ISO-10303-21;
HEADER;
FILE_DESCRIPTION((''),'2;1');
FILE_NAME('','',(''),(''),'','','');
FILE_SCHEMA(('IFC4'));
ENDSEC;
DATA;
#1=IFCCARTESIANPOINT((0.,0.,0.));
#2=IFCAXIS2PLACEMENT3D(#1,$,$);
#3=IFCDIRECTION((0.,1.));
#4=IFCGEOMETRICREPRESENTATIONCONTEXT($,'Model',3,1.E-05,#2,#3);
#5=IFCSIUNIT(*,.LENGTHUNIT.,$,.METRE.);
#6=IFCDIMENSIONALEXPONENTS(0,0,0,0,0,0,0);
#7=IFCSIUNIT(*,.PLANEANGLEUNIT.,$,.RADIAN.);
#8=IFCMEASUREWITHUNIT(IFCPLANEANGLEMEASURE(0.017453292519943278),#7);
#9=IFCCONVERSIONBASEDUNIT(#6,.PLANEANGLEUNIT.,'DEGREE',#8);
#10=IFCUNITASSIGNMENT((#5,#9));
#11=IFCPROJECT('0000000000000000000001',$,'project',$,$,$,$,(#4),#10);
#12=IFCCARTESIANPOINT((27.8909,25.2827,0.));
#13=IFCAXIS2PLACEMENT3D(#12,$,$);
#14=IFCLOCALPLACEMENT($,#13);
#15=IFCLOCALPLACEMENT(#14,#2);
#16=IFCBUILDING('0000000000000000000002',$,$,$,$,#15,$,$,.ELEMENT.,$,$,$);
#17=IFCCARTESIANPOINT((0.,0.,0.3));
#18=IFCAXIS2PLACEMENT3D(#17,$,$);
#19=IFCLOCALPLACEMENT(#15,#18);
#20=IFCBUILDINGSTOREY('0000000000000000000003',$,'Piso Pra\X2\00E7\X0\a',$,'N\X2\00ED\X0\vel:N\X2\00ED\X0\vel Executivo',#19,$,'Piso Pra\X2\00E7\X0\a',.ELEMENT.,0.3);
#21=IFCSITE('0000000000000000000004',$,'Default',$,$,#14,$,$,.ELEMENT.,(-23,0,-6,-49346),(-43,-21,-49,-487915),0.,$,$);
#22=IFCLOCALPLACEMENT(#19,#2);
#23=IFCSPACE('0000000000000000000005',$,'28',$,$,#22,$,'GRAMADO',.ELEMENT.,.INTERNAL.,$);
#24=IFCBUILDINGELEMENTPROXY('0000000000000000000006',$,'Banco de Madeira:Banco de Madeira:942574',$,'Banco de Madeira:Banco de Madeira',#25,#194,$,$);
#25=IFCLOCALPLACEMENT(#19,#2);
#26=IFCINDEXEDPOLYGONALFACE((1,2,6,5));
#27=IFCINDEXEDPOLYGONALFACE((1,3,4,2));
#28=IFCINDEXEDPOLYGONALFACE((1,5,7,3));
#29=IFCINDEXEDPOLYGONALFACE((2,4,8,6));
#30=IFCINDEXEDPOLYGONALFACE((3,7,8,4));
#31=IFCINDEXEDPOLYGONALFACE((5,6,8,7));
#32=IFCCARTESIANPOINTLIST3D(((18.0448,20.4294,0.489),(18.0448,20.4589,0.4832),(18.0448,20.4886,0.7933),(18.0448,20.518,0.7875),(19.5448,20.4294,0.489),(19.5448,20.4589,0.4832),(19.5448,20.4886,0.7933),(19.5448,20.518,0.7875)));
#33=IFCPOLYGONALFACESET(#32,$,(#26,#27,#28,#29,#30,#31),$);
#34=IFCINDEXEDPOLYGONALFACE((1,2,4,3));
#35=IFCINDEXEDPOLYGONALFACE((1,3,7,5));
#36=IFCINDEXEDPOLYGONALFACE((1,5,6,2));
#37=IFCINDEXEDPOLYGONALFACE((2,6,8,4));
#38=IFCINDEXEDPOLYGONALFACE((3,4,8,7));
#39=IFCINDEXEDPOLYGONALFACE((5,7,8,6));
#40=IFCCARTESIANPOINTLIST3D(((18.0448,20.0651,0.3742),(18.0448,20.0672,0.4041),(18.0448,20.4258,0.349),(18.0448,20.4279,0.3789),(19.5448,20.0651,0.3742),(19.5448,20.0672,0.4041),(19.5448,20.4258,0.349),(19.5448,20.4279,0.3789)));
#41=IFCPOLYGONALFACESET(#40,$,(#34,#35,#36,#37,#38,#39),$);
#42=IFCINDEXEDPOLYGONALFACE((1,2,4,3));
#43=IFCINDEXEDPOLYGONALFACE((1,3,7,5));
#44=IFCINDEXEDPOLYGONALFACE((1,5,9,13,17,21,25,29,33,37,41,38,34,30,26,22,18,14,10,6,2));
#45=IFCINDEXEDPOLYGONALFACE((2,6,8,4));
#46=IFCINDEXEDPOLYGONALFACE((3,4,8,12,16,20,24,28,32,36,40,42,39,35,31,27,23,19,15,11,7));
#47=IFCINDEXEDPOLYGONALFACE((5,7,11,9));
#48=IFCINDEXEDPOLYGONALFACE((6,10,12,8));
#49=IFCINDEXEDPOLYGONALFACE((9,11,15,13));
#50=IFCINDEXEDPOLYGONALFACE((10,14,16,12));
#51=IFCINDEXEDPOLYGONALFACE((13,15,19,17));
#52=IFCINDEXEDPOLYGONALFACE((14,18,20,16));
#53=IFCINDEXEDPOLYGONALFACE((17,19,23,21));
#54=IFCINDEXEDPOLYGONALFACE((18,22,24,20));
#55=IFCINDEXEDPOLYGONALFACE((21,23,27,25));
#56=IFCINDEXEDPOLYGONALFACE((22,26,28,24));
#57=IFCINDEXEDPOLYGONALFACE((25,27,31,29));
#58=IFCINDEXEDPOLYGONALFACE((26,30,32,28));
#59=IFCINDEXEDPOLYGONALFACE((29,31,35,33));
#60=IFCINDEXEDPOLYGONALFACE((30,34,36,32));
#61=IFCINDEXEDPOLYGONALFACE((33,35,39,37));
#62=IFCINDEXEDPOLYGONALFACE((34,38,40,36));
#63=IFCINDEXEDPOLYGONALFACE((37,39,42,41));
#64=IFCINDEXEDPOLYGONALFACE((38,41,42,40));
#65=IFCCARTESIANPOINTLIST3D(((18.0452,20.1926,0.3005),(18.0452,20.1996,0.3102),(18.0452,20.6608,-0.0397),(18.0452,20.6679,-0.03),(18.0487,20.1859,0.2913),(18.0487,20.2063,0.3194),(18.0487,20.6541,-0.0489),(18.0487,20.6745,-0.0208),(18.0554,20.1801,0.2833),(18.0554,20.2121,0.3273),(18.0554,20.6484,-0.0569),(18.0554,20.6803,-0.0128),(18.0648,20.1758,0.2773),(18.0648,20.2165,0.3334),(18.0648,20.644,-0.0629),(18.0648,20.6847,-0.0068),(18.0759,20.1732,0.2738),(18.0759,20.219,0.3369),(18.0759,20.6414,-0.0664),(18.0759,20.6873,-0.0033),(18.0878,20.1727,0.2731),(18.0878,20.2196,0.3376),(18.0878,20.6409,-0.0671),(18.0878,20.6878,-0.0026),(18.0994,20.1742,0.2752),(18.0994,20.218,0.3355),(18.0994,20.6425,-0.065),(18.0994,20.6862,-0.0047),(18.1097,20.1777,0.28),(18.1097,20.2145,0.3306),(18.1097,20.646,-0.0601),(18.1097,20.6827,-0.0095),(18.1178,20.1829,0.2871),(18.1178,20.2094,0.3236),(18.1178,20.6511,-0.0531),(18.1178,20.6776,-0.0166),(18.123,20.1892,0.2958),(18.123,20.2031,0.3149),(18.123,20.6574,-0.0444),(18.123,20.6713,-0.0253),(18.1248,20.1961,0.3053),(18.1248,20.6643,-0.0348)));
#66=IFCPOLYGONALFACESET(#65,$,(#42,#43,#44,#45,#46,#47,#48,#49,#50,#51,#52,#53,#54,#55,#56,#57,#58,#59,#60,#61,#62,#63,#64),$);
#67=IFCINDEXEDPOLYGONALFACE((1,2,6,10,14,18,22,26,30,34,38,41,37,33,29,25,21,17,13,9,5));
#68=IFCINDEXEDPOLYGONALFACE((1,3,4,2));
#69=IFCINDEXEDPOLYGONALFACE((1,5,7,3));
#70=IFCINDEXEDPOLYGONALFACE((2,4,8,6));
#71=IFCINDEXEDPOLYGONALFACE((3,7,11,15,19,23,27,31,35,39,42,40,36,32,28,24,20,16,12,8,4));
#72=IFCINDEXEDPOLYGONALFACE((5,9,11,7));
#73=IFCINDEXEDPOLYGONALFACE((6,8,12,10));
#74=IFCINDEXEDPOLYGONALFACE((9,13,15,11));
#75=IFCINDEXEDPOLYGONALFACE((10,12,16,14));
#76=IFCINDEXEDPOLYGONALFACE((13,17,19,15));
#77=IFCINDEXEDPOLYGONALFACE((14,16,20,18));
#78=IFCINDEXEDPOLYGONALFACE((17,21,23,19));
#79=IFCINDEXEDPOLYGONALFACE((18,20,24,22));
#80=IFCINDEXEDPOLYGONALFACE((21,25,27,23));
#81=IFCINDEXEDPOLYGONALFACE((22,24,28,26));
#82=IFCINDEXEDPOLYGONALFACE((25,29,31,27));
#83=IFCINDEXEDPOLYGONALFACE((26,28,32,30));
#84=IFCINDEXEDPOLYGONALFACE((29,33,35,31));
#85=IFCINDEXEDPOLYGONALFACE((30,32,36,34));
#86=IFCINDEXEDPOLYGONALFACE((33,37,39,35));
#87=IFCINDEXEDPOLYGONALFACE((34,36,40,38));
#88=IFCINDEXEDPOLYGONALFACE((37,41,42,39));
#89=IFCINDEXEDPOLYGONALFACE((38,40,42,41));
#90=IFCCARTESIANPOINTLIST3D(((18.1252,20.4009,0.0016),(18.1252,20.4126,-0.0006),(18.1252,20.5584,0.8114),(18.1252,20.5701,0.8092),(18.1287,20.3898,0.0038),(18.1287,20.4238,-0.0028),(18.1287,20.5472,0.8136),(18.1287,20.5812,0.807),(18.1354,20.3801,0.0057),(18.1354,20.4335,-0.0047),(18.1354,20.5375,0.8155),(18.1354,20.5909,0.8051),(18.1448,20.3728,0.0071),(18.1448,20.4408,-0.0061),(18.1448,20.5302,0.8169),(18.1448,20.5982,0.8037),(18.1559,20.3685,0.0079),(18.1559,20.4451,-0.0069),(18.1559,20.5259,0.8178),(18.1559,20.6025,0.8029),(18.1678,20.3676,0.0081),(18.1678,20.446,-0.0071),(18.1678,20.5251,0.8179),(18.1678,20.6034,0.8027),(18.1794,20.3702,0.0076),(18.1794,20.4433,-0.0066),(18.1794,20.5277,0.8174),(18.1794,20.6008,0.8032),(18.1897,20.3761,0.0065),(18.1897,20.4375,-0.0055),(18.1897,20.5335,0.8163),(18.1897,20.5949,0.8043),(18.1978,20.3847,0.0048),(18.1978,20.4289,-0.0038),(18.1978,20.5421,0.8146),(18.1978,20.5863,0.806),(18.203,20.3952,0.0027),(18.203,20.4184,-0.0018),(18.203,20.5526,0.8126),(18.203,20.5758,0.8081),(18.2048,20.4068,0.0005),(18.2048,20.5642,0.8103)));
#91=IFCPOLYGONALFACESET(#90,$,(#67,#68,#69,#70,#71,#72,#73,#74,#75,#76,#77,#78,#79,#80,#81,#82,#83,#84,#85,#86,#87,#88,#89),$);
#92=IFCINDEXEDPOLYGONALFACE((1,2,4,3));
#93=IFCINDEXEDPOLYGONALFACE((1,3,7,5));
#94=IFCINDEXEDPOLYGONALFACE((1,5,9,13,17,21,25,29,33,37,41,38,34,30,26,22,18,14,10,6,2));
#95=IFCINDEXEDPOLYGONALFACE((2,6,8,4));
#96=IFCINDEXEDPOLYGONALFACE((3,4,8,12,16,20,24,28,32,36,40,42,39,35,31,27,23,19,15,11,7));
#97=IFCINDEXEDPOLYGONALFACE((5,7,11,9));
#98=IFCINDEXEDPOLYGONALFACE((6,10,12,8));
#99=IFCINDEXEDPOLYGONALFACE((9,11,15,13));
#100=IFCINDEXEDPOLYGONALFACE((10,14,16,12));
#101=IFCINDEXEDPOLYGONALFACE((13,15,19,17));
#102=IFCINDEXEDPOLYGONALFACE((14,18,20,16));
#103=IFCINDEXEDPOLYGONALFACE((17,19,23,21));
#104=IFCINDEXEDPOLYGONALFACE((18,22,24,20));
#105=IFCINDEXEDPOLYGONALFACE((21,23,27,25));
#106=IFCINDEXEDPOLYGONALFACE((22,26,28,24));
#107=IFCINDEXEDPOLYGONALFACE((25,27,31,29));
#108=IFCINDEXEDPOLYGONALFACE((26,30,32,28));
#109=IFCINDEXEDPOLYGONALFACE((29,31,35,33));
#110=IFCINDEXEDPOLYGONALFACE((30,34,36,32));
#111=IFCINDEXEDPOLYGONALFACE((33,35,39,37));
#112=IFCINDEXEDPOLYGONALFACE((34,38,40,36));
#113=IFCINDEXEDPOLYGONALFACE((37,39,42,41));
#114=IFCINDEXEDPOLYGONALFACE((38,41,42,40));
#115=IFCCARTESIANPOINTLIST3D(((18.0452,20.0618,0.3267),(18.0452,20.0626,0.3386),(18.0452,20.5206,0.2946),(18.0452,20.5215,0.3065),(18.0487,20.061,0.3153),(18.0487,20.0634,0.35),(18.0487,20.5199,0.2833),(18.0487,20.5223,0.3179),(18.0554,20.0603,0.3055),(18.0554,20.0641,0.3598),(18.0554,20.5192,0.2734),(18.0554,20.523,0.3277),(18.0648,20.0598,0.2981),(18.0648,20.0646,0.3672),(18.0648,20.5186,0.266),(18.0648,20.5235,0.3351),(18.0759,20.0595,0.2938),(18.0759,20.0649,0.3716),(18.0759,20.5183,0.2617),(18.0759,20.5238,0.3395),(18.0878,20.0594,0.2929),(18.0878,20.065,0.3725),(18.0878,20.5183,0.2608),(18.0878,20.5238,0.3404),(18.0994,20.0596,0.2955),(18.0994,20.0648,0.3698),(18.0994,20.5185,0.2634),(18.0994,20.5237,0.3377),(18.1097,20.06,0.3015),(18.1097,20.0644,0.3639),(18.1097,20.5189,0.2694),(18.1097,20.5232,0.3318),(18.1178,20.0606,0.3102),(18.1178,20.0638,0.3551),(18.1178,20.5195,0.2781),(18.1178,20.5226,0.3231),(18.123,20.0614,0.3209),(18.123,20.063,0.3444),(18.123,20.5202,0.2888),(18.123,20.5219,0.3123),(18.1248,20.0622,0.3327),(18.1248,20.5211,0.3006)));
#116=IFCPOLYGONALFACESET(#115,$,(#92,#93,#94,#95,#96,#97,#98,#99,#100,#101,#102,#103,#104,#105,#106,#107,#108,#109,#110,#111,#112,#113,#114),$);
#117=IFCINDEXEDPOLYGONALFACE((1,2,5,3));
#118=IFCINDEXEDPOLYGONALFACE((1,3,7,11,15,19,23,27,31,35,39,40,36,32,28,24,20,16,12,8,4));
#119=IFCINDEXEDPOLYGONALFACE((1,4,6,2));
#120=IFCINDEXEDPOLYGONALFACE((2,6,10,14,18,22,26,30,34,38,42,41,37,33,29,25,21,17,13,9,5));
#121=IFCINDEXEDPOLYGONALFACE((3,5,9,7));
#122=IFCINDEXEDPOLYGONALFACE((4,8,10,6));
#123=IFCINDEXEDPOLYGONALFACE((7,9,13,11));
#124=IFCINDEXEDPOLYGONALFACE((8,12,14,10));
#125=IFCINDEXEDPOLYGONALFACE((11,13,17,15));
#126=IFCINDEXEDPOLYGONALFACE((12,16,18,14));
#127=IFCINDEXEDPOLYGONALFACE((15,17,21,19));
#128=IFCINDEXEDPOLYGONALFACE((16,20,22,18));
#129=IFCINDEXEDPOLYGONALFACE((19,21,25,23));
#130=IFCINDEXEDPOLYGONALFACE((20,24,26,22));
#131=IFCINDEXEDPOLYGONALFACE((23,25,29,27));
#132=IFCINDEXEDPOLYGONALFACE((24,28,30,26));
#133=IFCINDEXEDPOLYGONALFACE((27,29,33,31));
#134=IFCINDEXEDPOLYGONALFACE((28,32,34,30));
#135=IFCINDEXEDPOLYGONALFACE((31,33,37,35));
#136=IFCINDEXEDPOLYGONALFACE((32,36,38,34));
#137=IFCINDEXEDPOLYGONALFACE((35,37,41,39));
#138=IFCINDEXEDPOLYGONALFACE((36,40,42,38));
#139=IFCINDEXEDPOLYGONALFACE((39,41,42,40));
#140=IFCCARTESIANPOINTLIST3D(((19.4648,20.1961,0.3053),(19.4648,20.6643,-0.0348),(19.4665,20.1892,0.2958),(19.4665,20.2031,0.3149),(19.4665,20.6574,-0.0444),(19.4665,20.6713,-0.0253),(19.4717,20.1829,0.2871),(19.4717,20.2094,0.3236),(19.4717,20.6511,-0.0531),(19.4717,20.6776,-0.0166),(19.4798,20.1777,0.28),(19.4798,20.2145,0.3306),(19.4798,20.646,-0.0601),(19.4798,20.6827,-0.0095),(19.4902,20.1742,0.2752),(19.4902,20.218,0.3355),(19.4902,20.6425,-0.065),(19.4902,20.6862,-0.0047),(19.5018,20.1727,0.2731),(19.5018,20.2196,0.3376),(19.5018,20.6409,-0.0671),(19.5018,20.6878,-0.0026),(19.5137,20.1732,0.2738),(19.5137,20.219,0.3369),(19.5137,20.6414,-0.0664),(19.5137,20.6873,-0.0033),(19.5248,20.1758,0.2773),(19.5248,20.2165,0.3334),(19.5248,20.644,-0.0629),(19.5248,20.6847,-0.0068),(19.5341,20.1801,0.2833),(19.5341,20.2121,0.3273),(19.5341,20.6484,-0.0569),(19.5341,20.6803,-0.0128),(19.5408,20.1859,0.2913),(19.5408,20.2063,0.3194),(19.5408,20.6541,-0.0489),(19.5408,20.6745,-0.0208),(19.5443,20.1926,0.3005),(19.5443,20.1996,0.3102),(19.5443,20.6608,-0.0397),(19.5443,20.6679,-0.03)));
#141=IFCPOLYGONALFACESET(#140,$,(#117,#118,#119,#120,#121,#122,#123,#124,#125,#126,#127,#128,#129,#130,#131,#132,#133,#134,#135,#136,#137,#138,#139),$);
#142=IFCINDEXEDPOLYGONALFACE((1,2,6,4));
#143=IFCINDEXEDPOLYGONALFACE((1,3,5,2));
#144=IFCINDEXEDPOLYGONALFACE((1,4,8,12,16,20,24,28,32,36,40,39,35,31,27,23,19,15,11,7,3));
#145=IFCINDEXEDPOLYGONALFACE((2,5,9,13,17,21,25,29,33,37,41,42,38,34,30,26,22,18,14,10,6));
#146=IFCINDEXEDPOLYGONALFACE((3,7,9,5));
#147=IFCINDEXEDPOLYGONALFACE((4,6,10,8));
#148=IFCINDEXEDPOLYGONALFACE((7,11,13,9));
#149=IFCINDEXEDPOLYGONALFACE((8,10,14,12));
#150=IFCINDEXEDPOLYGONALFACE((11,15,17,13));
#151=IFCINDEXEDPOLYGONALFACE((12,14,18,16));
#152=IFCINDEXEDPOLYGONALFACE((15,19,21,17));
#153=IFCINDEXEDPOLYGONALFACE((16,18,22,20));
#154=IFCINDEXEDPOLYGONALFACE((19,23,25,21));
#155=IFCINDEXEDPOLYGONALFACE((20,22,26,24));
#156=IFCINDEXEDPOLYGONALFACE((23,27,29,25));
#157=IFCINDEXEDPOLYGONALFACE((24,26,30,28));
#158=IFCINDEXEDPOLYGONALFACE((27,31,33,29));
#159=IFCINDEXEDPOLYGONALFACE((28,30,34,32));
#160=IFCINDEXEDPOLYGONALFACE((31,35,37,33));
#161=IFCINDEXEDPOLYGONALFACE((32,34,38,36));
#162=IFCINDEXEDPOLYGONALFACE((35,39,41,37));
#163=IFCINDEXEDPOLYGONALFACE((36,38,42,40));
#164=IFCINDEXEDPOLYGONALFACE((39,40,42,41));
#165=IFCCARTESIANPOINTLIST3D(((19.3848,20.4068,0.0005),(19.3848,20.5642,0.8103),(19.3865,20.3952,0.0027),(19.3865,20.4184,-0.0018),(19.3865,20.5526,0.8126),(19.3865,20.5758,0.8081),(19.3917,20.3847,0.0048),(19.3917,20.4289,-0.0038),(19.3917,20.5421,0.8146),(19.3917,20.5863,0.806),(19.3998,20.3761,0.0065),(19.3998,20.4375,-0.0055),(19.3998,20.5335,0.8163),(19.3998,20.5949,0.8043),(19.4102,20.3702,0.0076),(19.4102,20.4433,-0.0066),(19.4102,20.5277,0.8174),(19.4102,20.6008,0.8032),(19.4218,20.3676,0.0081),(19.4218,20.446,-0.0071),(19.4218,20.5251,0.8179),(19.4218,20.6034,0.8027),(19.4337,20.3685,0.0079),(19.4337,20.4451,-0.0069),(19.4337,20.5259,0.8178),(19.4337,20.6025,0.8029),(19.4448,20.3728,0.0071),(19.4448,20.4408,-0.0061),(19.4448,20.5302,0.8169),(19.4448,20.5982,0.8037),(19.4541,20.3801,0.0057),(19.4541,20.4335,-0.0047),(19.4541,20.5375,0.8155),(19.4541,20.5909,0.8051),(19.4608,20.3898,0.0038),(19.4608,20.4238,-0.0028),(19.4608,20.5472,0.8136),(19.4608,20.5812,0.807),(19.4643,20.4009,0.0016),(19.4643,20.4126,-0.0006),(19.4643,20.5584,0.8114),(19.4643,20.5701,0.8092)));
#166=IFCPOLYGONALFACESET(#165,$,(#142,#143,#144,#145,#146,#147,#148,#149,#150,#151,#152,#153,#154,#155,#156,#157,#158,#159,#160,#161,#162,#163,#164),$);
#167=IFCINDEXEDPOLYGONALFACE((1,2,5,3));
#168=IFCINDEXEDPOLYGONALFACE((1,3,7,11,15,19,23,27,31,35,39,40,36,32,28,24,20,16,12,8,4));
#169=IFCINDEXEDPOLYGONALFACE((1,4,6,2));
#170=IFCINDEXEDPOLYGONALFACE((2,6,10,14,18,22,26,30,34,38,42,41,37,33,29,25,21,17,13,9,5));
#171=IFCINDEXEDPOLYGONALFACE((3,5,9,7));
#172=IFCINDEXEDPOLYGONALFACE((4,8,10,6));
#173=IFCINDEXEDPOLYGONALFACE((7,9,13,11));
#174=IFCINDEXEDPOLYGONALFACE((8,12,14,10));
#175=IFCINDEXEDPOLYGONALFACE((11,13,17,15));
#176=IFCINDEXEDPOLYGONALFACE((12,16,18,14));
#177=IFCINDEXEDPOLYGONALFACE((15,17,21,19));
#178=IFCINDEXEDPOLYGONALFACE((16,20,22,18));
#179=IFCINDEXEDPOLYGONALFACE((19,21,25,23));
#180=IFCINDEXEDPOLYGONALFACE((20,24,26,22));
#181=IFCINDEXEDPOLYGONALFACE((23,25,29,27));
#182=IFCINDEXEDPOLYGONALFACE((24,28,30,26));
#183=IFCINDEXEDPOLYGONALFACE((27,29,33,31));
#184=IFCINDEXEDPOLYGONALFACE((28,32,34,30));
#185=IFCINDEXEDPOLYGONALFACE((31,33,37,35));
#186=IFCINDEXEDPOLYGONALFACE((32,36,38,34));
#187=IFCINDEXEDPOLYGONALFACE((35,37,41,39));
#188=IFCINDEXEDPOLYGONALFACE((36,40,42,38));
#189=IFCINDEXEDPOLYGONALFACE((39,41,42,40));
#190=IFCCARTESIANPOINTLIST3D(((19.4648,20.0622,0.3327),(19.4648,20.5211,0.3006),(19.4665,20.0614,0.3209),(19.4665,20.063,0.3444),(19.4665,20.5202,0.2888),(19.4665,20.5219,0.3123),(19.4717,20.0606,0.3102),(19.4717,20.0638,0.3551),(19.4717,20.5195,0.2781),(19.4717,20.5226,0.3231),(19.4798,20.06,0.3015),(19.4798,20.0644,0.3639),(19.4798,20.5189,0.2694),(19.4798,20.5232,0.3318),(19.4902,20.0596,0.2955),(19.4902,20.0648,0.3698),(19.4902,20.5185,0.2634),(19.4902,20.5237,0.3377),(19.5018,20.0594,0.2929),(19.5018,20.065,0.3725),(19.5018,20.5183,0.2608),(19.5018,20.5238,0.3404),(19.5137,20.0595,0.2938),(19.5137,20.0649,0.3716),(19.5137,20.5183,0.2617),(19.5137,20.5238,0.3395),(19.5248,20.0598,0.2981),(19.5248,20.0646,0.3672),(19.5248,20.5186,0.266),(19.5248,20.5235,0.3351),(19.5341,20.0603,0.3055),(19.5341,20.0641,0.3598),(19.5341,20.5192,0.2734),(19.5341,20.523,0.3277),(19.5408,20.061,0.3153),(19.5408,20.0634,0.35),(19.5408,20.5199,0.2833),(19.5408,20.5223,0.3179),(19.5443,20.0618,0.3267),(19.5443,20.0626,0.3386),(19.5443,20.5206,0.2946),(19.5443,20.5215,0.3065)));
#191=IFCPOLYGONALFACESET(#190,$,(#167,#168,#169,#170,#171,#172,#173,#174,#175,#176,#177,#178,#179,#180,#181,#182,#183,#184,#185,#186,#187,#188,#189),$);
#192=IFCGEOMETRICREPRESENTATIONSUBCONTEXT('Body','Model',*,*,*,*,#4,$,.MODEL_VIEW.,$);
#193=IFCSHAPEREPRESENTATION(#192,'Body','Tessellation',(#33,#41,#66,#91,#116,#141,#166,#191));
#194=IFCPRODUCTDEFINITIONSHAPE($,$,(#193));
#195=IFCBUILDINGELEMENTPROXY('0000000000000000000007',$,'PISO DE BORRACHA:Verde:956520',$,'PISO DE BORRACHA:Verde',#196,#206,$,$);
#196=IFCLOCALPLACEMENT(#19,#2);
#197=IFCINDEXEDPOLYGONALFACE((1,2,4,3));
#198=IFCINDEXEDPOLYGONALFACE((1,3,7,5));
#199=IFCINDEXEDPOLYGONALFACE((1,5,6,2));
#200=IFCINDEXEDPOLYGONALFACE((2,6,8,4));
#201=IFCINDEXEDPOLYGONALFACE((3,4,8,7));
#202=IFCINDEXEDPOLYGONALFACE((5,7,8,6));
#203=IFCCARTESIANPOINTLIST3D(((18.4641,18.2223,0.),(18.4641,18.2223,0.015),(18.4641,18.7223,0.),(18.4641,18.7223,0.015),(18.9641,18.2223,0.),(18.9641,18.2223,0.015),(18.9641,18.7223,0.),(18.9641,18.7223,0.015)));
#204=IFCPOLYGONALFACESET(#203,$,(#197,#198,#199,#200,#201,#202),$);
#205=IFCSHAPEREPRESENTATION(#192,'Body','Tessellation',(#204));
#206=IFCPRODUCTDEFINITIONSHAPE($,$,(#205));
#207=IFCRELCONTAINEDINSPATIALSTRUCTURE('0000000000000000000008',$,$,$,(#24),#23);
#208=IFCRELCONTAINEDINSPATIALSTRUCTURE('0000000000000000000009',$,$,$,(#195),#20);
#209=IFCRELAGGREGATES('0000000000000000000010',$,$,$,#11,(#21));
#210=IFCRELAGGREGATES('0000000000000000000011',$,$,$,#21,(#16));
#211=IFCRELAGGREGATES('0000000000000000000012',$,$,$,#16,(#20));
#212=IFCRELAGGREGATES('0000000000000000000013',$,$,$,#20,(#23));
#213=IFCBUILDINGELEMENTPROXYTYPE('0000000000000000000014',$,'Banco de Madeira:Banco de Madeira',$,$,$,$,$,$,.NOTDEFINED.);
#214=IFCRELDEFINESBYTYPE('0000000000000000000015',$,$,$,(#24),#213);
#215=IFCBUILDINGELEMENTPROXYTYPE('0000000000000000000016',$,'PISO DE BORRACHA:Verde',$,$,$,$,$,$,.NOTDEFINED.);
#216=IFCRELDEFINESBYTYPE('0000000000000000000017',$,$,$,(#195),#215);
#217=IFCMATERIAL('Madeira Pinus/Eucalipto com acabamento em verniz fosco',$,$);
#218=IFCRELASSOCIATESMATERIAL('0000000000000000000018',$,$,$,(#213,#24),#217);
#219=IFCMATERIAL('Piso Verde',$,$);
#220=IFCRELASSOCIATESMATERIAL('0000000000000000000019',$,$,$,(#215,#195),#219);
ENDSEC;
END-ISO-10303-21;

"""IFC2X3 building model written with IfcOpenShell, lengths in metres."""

from ifc_helpers import new_model, entity, si_unit, converted_unit, direction, frame, frame_2d, origin, origin_2d_with_axis, place, context, subcontext, project, spatial, rectangle, circle, extrude, source, transform, mapped, material, type_object, type_shapes, element, save


model = new_model("IFC2X3")

# Units and contexts
model_context = context("Model", 3, precision=1e-05, world=origin(), true_north=direction((0.0, 1.0)))
body_context = subcontext(model_context, "Body", "Model", "MODEL_VIEW")
ifc_project = project(units=[si_unit("LENGTHUNIT", "METRE"), converted_unit("PLANEANGLEUNIT", "DEGREE", entity("IfcPlaneAngleMeasure", 0.017453292519943278), si_unit("PLANEANGLEUNIT", "RADIAN"), dimensions=[0, 0, 0, 0, 0, 0, 0])], contexts=[model_context])

# Site, building, storey, space
site_placement = place(None, frame((27.8909, 25.2827, 0.0)))
site = spatial("IfcSite", under=ifc_project, at=site_placement, Name="Default", CompositionType="ELEMENT", RefLatitude=(-23, 0, -6, -49346), RefLongitude=(-43, -21, -49, -487915), RefElevation=0.0)
building_placement = place(site_placement, origin())
building = spatial("IfcBuilding", under=site, at=building_placement, CompositionType="ELEMENT")
storey_placement = place(building_placement, frame((0.0, 0.0, 0.3)))
storey = spatial("IfcBuildingStorey", under=building, at=storey_placement, Name="Piso Praça", ObjectType="Nível:Nível Executivo", LongName="Piso Praça", CompositionType="ELEMENT", Elevation=0.3)
space_placement = place(storey_placement, origin())
space = spatial("IfcSpace", under=storey, at=space_placement, Name="28", LongName="GRAMADO", CompositionType="ELEMENT", InteriorOrExteriorSpace="INTERNAL")

# Building element proxies
ifc_material_1 = material(Name="Madeira Pinus/Eucalipto com acabamento em verniz fosco")
building_element_proxy_type_1 = type_object("IfcBuildingElementProxyType", Name="Banco de Madeira:Banco de Madeira", PredefinedType="NOTDEFINED", material=ifc_material_1)
shared_shape_1 = source(origin(), body_context, "Body", "SweptSolid", [
    extrude(rectangle(XDim=0.31, YDim=0.03, at=frame_2d((0.0, 0.0), x_axis=(0.0, 1.0))), frame((-0.75, -0.1439, 0.6383), z_axis=(1.0, 0.0, 0.0), x_axis=(0.0, 0.981627, 0.190809)), (0.0, 0.0, 1.0), 1.5),
    extrude(rectangle(XDim=0.03, YDim=0.3616, at=frame_2d((0.0, 0.0), x_axis=(1.0, 0.0))), frame((-0.75, 0.0833, 0.3765), z_axis=(1.0, 0.0, 0.0), x_axis=(0.0, -0.069756, 0.997564)), (0.0, 0.0, 1.0), 1.5),
    extrude(circle(Radius=0.04, at=frame_2d((0.0, 0.0), x_axis=(1.0, 0.0))), frame((0.71, -0.3345, -0.0348), z_axis=(0.0, 0.809017, 0.587785), x_axis=(-1.0, 0.0, 0.0)), (0.0, 0.0, 1.0), 0.5788),
    extrude(circle(Radius=0.04, at=frame_2d((0.0, 0.0), x_axis=(1.0, 0.0))), frame((0.63, -0.2344, 0.8103), z_axis=(0.0, 0.190809, -0.981627), x_axis=(-1.0, 0.0, 0.0)), (0.0, 0.0, 1.0), 0.825),
    extrude(circle(Radius=0.04, at=frame_2d((0.0, 0.0), x_axis=(1.0, 0.0))), frame((0.71, -0.1913, 0.3006), z_axis=(0.0, 0.997564, 0.069756), x_axis=(-1.0, 0.0, 0.0)), (0.0, 0.0, 1.0), 0.46),
    extrude(circle(Radius=0.04, at=frame_2d((0.0, 0.0), x_axis=(1.0, 0.0))), frame((-0.71, -0.3345, -0.0348), z_axis=(0.0, 0.809017, 0.587785), x_axis=(1.0, 0.0, 0.0)), (0.0, 0.0, 1.0), 0.5788),
    extrude(circle(Radius=0.04, at=frame_2d((0.0, 0.0), x_axis=(1.0, 0.0))), frame((-0.63, -0.2344, 0.8103), z_axis=(0.0, 0.190809, -0.981627), x_axis=(1.0, 0.0, 0.0)), (0.0, 0.0, 1.0), 0.825),
    extrude(circle(Radius=0.04, at=frame_2d((0.0, 0.0), x_axis=(1.0, 0.0))), frame((-0.71, -0.1913, 0.3006), z_axis=(0.0, 0.997564, 0.069756), x_axis=(1.0, 0.0, 0.0)), (0.0, 0.0, 1.0), 0.46),
])
type_shapes(building_element_proxy_type_1, [shared_shape_1])
proxy_placement = place(space_placement, frame((18.7948, 20.3298, 0.0), z_axis=(0.0, 0.0, 1.0), x_axis=(-1.0, 0.0, 0.0)))
element("IfcBuildingElementProxy", 1, at=proxy_placement, inside=space, type_object=building_element_proxy_type_1, material=ifc_material_1, Name="Banco de Madeira:Banco de Madeira:942574", ObjectType="Banco de Madeira:Banco de Madeira", context=body_context, shape_type="MappedRepresentation", body=[
    mapped(shared_shape_1, transform((0.0, 0.0, 0.0), scale=1.0)),
])
ifc_material_2 = material(Name="Piso Verde")
building_element_proxy_type_2 = type_object("IfcBuildingElementProxyType", Name="PISO DE BORRACHA:Verde", PredefinedType="NOTDEFINED", material=ifc_material_2)
shared_shape_2 = source(origin(), body_context, "Body", "SweptSolid", [
    extrude(rectangle(XDim=0.5, YDim=0.5, at=origin_2d_with_axis()), frame((0.25, 0.25, 0.0), z_axis=(0.0, 0.0, 1.0), x_axis=(-1.0, 0.0, 0.0)), (0.0, 0.0, 1.0), 0.015),
])
type_shapes(building_element_proxy_type_2, [shared_shape_2])
for number, where, name in (
    (2, (18.4641, 18.2223, 0.0), "PISO DE BORRACHA:Verde:956520"),
):
    element("IfcBuildingElementProxy", number, at=place(storey_placement, frame(where)), inside=storey, type_object=building_element_proxy_type_2, material=ifc_material_2, Name=name, ObjectType="PISO DE BORRACHA:Verde", context=body_context, shape_type="MappedRepresentation", body=[
        mapped(shared_shape_2, transform((0.0, 0.0, 0.0), scale=1.0)),
    ])

save(model, "model.ifc")
